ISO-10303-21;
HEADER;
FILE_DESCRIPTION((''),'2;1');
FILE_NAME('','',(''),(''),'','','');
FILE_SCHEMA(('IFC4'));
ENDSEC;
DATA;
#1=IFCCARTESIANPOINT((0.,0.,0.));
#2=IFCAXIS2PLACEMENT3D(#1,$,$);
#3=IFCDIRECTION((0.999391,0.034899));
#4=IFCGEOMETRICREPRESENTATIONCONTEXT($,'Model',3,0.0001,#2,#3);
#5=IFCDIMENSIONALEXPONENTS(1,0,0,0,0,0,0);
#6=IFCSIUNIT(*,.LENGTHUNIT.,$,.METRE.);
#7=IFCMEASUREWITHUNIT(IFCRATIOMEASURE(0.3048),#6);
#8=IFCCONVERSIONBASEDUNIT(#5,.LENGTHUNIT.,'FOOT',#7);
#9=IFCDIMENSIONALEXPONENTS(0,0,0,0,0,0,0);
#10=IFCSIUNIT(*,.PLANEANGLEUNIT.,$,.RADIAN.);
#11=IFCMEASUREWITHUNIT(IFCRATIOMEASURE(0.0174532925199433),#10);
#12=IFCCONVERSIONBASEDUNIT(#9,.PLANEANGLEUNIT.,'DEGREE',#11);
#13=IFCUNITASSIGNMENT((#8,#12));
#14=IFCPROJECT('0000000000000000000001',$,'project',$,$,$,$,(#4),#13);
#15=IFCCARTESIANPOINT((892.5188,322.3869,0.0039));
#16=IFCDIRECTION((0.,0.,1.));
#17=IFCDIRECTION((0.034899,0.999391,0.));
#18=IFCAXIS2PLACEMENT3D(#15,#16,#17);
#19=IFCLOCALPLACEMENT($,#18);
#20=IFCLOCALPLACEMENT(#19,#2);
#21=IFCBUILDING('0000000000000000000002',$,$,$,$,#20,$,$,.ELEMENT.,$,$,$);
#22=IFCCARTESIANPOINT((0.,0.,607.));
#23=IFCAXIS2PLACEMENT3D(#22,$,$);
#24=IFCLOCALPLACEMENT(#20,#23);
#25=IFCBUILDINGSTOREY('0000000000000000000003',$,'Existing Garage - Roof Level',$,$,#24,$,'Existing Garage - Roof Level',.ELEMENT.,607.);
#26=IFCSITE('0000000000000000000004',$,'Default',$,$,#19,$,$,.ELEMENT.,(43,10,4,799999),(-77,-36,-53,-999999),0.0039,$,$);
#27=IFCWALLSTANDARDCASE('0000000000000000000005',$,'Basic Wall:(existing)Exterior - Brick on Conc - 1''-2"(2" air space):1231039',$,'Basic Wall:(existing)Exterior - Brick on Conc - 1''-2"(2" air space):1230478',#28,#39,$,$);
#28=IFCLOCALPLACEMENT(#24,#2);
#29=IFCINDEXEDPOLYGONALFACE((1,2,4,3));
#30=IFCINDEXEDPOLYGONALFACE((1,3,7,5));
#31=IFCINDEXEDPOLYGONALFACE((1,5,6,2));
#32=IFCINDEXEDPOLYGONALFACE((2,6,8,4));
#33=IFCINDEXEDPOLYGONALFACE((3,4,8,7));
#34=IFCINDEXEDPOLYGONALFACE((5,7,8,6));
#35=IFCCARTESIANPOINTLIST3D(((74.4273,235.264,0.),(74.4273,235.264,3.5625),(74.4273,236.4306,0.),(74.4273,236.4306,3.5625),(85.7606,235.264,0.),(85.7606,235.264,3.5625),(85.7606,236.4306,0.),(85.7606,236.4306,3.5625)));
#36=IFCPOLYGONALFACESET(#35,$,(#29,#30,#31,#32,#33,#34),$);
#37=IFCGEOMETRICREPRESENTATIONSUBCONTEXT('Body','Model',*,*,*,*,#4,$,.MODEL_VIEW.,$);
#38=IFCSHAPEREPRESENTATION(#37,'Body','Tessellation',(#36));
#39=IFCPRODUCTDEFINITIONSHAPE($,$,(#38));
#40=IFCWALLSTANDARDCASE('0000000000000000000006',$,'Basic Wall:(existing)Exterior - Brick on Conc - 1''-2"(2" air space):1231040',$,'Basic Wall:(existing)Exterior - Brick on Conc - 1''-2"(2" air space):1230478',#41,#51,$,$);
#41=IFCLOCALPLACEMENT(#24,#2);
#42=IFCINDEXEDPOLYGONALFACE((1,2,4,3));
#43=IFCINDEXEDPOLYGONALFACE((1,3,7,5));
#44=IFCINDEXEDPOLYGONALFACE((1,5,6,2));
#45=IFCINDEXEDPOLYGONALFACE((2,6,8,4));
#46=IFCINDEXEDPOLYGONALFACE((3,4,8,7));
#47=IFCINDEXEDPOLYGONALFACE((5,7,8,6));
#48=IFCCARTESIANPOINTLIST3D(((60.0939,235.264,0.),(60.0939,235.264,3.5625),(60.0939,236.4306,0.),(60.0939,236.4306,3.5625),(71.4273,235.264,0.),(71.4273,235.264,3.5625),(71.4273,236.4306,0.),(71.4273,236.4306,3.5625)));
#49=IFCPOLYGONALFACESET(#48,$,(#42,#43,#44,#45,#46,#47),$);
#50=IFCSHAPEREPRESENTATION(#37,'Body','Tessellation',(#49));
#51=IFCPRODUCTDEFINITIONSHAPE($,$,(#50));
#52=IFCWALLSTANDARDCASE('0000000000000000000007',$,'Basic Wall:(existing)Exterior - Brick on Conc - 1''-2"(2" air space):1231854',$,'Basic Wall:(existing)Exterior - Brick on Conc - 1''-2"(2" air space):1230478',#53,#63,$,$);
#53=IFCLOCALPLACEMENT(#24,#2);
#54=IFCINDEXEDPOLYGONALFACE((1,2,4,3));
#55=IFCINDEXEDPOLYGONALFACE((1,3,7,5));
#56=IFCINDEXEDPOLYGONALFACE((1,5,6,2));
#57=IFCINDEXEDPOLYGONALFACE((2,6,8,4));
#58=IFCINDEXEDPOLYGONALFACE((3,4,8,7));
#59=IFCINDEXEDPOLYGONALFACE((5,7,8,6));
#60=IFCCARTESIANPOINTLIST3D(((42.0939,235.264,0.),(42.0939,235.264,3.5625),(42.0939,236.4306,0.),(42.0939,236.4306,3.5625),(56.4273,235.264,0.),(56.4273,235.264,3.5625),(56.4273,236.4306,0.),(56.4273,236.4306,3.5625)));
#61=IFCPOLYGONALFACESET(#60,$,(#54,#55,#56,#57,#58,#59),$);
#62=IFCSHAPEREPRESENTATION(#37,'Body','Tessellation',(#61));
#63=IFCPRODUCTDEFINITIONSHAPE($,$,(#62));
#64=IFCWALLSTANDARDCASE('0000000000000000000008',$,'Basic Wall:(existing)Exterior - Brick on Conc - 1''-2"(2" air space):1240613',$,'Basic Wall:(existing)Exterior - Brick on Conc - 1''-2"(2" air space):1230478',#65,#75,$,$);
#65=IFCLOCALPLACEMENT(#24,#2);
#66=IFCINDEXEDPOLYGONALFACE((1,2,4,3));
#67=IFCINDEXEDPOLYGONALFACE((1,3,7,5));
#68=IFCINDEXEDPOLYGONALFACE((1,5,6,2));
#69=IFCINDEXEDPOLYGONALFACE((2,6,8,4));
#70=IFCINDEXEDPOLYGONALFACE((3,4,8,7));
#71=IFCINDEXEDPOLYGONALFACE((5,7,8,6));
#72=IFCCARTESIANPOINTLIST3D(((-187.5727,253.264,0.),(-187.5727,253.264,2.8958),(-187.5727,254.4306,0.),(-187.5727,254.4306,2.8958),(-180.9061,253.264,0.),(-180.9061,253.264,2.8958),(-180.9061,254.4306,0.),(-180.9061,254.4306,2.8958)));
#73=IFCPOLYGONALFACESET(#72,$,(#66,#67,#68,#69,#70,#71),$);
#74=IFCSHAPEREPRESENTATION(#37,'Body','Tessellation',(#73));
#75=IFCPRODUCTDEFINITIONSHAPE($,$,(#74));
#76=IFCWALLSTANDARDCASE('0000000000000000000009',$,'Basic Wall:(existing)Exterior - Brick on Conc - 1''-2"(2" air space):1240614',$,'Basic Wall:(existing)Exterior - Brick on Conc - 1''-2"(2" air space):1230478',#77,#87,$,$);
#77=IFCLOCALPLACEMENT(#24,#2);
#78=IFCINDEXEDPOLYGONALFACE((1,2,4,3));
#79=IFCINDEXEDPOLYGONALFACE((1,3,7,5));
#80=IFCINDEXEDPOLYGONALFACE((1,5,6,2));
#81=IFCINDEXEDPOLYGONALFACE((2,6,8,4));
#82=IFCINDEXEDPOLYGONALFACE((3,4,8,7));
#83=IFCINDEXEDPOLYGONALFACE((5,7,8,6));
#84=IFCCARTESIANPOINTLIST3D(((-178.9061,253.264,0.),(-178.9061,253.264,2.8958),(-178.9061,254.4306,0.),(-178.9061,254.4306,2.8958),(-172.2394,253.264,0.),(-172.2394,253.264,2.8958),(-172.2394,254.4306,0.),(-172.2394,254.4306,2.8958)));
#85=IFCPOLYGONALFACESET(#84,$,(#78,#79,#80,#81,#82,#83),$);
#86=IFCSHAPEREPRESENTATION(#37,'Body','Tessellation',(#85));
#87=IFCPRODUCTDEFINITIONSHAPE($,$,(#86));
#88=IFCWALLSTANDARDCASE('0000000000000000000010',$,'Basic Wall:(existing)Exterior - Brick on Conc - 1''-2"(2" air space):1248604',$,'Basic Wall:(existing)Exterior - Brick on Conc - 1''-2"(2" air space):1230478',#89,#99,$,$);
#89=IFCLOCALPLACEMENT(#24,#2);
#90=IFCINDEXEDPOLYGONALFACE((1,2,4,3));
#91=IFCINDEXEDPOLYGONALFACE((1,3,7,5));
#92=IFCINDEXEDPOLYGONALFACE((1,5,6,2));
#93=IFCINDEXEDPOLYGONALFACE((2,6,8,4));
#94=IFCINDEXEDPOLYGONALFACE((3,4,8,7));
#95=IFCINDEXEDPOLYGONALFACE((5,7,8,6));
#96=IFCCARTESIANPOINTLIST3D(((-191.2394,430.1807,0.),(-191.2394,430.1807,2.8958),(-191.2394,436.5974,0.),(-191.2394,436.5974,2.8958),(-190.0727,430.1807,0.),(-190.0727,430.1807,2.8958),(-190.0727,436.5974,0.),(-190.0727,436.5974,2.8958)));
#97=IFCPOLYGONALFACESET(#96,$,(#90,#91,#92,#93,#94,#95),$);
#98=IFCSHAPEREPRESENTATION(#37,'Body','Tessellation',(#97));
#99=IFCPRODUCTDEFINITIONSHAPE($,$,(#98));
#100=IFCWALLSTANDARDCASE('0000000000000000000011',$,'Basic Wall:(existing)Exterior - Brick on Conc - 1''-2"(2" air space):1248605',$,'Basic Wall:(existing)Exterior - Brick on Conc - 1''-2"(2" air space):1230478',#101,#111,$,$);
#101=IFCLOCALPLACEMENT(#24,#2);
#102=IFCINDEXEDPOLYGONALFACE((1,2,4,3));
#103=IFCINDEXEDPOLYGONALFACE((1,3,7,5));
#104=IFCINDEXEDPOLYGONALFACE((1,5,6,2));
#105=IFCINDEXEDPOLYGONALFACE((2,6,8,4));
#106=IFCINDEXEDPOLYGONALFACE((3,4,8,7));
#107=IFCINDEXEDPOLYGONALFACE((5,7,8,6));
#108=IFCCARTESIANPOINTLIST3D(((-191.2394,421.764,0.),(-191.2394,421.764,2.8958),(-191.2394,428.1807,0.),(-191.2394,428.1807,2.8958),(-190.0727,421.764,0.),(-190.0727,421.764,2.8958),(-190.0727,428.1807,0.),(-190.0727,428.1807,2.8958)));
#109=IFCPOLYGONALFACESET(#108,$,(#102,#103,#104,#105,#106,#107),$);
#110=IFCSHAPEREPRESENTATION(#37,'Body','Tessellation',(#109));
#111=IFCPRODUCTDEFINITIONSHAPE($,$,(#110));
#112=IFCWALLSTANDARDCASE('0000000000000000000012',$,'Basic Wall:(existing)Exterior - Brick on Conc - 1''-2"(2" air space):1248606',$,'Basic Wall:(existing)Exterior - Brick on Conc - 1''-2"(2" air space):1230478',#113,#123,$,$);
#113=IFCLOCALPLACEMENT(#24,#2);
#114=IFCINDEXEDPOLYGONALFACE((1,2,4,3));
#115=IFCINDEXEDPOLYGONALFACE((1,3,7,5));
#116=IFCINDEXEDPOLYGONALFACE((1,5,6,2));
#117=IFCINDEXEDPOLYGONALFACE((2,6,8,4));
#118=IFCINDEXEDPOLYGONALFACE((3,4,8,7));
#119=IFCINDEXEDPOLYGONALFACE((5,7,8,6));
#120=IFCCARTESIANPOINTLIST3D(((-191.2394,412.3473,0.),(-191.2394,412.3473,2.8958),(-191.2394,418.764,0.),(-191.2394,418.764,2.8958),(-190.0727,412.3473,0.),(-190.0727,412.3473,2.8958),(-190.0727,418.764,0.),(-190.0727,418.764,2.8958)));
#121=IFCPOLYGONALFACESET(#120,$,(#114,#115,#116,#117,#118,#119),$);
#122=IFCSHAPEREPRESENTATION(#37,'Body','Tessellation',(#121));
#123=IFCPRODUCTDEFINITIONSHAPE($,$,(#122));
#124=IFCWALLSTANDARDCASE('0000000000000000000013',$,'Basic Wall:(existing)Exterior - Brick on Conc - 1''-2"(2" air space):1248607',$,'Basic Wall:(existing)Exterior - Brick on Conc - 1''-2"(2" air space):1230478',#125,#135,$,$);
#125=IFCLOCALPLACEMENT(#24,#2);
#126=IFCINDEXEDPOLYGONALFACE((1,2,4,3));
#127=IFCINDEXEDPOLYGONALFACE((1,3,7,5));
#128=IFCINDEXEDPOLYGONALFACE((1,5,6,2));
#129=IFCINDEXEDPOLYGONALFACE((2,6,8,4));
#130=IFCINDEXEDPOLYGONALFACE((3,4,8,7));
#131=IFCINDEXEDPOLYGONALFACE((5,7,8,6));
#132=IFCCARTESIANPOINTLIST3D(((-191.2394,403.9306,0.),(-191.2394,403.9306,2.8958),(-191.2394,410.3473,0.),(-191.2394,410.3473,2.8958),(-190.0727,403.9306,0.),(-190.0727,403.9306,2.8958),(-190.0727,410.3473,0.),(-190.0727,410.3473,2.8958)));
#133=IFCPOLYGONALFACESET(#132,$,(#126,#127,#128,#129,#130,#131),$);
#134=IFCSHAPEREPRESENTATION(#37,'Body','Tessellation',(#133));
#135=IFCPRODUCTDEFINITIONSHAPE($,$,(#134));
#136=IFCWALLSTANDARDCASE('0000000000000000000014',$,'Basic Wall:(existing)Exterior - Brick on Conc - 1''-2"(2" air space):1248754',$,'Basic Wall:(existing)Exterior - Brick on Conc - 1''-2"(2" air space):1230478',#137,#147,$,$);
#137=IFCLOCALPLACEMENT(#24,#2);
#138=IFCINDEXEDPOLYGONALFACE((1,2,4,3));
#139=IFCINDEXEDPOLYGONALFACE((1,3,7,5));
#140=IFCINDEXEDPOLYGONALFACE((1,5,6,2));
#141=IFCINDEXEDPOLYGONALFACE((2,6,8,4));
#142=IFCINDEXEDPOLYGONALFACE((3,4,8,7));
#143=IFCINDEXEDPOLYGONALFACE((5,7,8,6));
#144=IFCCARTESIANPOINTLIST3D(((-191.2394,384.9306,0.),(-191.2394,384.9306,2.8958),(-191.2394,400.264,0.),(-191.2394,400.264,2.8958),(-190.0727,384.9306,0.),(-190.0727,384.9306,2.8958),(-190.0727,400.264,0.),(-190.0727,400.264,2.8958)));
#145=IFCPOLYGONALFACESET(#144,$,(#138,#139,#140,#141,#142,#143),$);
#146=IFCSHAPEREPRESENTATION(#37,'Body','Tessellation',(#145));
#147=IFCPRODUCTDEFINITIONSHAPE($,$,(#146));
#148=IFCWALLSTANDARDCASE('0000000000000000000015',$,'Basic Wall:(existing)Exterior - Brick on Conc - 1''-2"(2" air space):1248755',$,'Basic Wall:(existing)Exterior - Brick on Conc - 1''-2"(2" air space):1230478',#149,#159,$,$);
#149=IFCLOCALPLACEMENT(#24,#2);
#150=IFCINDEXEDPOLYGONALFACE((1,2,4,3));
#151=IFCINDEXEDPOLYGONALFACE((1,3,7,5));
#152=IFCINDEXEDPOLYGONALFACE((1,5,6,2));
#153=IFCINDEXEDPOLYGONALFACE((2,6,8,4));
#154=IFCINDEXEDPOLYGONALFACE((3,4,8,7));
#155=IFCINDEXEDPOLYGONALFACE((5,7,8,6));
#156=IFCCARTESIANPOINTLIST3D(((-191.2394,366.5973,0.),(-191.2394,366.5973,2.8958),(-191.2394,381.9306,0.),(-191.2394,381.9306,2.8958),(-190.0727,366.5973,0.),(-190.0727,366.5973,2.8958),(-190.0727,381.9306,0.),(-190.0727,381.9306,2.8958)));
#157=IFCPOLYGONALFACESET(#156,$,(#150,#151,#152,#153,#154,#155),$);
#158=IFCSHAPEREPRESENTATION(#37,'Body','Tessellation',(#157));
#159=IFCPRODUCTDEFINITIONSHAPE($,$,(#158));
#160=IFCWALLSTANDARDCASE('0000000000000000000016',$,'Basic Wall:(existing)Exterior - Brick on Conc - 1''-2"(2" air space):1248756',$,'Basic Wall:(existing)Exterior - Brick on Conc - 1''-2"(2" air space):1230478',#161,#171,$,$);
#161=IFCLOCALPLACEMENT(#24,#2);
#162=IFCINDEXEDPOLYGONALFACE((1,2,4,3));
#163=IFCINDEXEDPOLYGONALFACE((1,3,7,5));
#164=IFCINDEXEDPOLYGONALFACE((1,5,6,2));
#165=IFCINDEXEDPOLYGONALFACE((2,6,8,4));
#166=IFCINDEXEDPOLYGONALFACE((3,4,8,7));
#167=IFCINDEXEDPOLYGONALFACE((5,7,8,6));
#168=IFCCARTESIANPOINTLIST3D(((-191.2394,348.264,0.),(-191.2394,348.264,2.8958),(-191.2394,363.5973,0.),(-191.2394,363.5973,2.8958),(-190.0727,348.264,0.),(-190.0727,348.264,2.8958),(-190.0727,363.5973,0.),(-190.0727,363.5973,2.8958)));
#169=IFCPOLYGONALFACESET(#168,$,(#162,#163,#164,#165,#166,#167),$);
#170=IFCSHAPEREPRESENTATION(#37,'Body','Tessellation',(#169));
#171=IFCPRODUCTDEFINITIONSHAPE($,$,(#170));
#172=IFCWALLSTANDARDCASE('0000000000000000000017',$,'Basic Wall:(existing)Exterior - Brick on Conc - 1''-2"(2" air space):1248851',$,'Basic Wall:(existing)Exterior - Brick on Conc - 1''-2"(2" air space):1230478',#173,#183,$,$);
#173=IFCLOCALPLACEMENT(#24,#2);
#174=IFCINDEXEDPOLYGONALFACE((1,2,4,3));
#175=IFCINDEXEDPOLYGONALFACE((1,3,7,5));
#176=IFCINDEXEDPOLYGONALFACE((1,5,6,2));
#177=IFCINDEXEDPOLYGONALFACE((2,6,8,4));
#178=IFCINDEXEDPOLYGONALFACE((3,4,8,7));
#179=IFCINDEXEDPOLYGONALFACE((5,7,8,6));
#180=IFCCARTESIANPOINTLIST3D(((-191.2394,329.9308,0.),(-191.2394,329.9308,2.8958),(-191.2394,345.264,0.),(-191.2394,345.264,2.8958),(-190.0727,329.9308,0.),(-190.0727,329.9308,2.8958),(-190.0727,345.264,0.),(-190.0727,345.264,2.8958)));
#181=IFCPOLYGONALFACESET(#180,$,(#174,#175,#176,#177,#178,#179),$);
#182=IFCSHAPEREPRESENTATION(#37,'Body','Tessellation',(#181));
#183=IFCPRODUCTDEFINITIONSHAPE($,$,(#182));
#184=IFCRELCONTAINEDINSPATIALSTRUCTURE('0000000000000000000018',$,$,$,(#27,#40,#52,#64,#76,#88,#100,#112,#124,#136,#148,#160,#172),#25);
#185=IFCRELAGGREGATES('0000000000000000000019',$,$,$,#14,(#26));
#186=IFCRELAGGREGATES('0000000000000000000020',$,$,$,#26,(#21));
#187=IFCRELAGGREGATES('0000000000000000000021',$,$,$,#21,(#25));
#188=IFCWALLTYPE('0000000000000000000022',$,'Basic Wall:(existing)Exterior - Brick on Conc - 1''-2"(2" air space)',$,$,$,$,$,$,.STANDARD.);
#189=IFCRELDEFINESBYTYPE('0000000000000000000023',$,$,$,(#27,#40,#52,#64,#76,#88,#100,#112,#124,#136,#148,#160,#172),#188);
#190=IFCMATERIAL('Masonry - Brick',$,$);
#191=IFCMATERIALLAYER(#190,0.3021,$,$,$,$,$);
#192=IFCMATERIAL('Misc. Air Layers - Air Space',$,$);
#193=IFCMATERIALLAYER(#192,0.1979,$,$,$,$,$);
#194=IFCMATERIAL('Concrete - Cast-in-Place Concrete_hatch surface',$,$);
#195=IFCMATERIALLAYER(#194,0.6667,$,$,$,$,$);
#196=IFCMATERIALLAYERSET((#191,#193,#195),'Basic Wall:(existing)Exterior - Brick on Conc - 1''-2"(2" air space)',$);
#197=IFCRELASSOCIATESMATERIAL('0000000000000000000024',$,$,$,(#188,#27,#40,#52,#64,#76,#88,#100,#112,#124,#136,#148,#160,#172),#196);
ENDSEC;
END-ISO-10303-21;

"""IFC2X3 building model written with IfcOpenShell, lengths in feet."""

from ifc_helpers import new_model, entity, si_unit, converted_unit, direction, frame, frame_2d, origin, place, context, subcontext, project, spatial, rectangle, extrude, material, layer, layer_set, layer_usage, type_object, element, save


model = new_model("IFC2X3")

# Units and contexts
model_context = context("Model", 3, precision=0.0001, world=origin(), true_north=direction((0.999391, 0.034899)))
body_context = subcontext(model_context, "Body", "Model", "MODEL_VIEW")
ifc_project = project(units=[converted_unit("LENGTHUNIT", "FOOT", entity("IfcRatioMeasure", 0.3048), si_unit("LENGTHUNIT", "METRE"), dimensions=[1, 0, 0, 0, 0, 0, 0]), converted_unit("PLANEANGLEUNIT", "DEGREE", entity("IfcRatioMeasure", 0.0174532925199433), si_unit("PLANEANGLEUNIT", "RADIAN"), dimensions=[0, 0, 0, 0, 0, 0, 0])], contexts=[model_context])

# Site, building, storey
site_placement = place(None, frame((892.5188, 322.3869, 0.0039), z_axis=(0.0, 0.0, 1.0), x_axis=(0.034899, 0.999391, 0.0)))
site = spatial("IfcSite", under=ifc_project, at=site_placement, Name="Default", CompositionType="ELEMENT", RefLatitude=(43, 10, 4, 799999), RefLongitude=(-77, -36, -53, -999999), RefElevation=0.0039)
building_placement = place(site_placement, origin())
building = spatial("IfcBuilding", under=site, at=building_placement, CompositionType="ELEMENT")
storey_placement = place(building_placement, frame((0.0, 0.0, 607.0)))
storey = spatial("IfcBuildingStorey", under=building, at=storey_placement, Name="Existing Garage - Roof Level", LongName="Existing Garage - Roof Level", CompositionType="ELEMENT", Elevation=607.0)

# Walls
ifc_material_1 = material(Name="Masonry - Brick")
ifc_layer_1 = layer(ifc_material_1, 0.3021)
ifc_material_2 = material(Name="Misc. Air Layers - Air Space")
ifc_layer_2 = layer(ifc_material_2, 0.1979)
ifc_material_3 = material(Name="Concrete - Cast-in-Place Concrete_hatch surface")
ifc_layer_3 = layer(ifc_material_3, 0.6667)
ifc_layer_set_1 = layer_set([ifc_layer_1, ifc_layer_2, ifc_layer_3], Name="Basic Wall:(existing)Exterior - Brick on Conc - 1'-2\"(2\" air space)")
ifc_layer_usage_1 = layer_usage(ifc_layer_set_1, "AXIS2", "POSITIVE", -0.5833)
wall_type_1 = type_object("IfcWallType", Name="Basic Wall:(existing)Exterior - Brick on Conc - 1'-2\"(2\" air space)", PredefinedType="STANDARD", material=ifc_layer_set_1)
wall_1_placement = place(storey_placement, frame((74.4273, 235.8473, 0.0)))
element("IfcWallStandardCase", 1, at=wall_1_placement, inside=storey, type_object=wall_type_1, material=ifc_layer_usage_1, Name="Basic Wall:(existing)Exterior - Brick on Conc - 1'-2\"(2\" air space):1231039", ObjectType="Basic Wall:(existing)Exterior - Brick on Conc - 1'-2\"(2\" air space):1230478", context=body_context, shape_type="SweptSolid", body=[
    extrude(rectangle(XDim=11.3333, YDim=1.1667, at=frame_2d((5.6667, 0.0), x_axis=(-1.0, 0.0))), origin(), (0.0, 0.0, 1.0), 3.5625),
])
ifc_layer_usage_2 = layer_usage(ifc_layer_set_1, "AXIS2", "POSITIVE", -0.5833)
wall_2_placement = place(storey_placement, frame((60.0939, 235.8473, 0.0)))
element("IfcWallStandardCase", 2, at=wall_2_placement, inside=storey, type_object=wall_type_1, material=ifc_layer_usage_2, Name="Basic Wall:(existing)Exterior - Brick on Conc - 1'-2\"(2\" air space):1231040", ObjectType="Basic Wall:(existing)Exterior - Brick on Conc - 1'-2\"(2\" air space):1230478", context=body_context, shape_type="SweptSolid", body=[
    extrude(rectangle(XDim=11.3334, YDim=1.1667, at=frame_2d((5.6667, 0.0), x_axis=(-1.0, 0.0))), origin(), (0.0, 0.0, 1.0), 3.5625),
])
ifc_layer_usage_3 = layer_usage(ifc_layer_set_1, "AXIS2", "POSITIVE", -0.5833)
wall_3_placement = place(storey_placement, frame((42.0939, 235.8473, 0.0)))
element("IfcWallStandardCase", 3, at=wall_3_placement, inside=storey, type_object=wall_type_1, material=ifc_layer_usage_3, Name="Basic Wall:(existing)Exterior - Brick on Conc - 1'-2\"(2\" air space):1231854", ObjectType="Basic Wall:(existing)Exterior - Brick on Conc - 1'-2\"(2\" air space):1230478", context=body_context, shape_type="SweptSolid", body=[
    extrude(rectangle(XDim=14.3333, YDim=1.1667, at=frame_2d((7.1667, 0.0), x_axis=(-1.0, 0.0))), origin(), (0.0, 0.0, 1.0), 3.5625),
])
ifc_layer_usage_4 = layer_usage(ifc_layer_set_1, "AXIS2", "POSITIVE", -0.5833)
wall_4_placement = place(storey_placement, frame((-187.5727, 253.8473, 0.0)))
element("IfcWallStandardCase", 4, at=wall_4_placement, inside=storey, type_object=wall_type_1, material=ifc_layer_usage_4, Name="Basic Wall:(existing)Exterior - Brick on Conc - 1'-2\"(2\" air space):1240613", ObjectType="Basic Wall:(existing)Exterior - Brick on Conc - 1'-2\"(2\" air space):1230478", context=body_context, shape_type="SweptSolid", body=[
    extrude(rectangle(XDim=6.6667, YDim=1.1667, at=frame_2d((3.3333, 0.0), x_axis=(-1.0, 0.0))), origin(), (0.0, 0.0, 1.0), 2.8958),
])
ifc_layer_usage_5 = layer_usage(ifc_layer_set_1, "AXIS2", "POSITIVE", -0.5833)
wall_5_placement = place(storey_placement, frame((-178.9061, 253.8473, 0.0)))
element("IfcWallStandardCase", 5, at=wall_5_placement, inside=storey, type_object=wall_type_1, material=ifc_layer_usage_5, Name="Basic Wall:(existing)Exterior - Brick on Conc - 1'-2\"(2\" air space):1240614", ObjectType="Basic Wall:(existing)Exterior - Brick on Conc - 1'-2\"(2\" air space):1230478", context=body_context, shape_type="SweptSolid", body=[
    extrude(rectangle(XDim=6.6667, YDim=1.1667, at=frame_2d((3.3333, 0.0), x_axis=(-1.0, 0.0))), origin(), (0.0, 0.0, 1.0), 2.8958),
])
ifc_layer_usage_6 = layer_usage(ifc_layer_set_1, "AXIS2", "POSITIVE", -0.5833)
wall_6_placement = place(storey_placement, frame((-190.6561, 436.5974, 0.0), z_axis=(0.0, 0.0, 1.0), x_axis=(0.0, -1.0, 0.0)))
element("IfcWallStandardCase", 6, at=wall_6_placement, inside=storey, type_object=wall_type_1, material=ifc_layer_usage_6, Name="Basic Wall:(existing)Exterior - Brick on Conc - 1'-2\"(2\" air space):1248604", ObjectType="Basic Wall:(existing)Exterior - Brick on Conc - 1'-2\"(2\" air space):1230478", context=body_context, shape_type="SweptSolid", body=[
    extrude(rectangle(XDim=6.4167, YDim=1.1667, at=frame_2d((3.2084, 0.0), x_axis=(-1.0, 0.0))), origin(), (0.0, 0.0, 1.0), 2.8958),
])
ifc_layer_usage_7 = layer_usage(ifc_layer_set_1, "AXIS2", "POSITIVE", -0.5833)
wall_7_placement = place(storey_placement, frame((-190.6561, 428.1807, 0.0), z_axis=(0.0, 0.0, 1.0), x_axis=(0.0, -1.0, 0.0)))
element("IfcWallStandardCase", 7, at=wall_7_placement, inside=storey, type_object=wall_type_1, material=ifc_layer_usage_7, Name="Basic Wall:(existing)Exterior - Brick on Conc - 1'-2\"(2\" air space):1248605", ObjectType="Basic Wall:(existing)Exterior - Brick on Conc - 1'-2\"(2\" air space):1230478", context=body_context, shape_type="SweptSolid", body=[
    extrude(rectangle(XDim=6.4167, YDim=1.1667, at=frame_2d((3.2084, 0.0), x_axis=(-1.0, 0.0))), origin(), (0.0, 0.0, 1.0), 2.8958),
])
ifc_layer_usage_8 = layer_usage(ifc_layer_set_1, "AXIS2", "POSITIVE", -0.5833)
wall_8_placement = place(storey_placement, frame((-190.6561, 418.764, 0.0), z_axis=(0.0, 0.0, 1.0), x_axis=(0.0, -1.0, 0.0)))
element("IfcWallStandardCase", 8, at=wall_8_placement, inside=storey, type_object=wall_type_1, material=ifc_layer_usage_8, Name="Basic Wall:(existing)Exterior - Brick on Conc - 1'-2\"(2\" air space):1248606", ObjectType="Basic Wall:(existing)Exterior - Brick on Conc - 1'-2\"(2\" air space):1230478", context=body_context, shape_type="SweptSolid", body=[
    extrude(rectangle(XDim=6.4167, YDim=1.1667, at=frame_2d((3.2084, 0.0), x_axis=(-1.0, 0.0))), origin(), (0.0, 0.0, 1.0), 2.8958),
])
ifc_layer_usage_9 = layer_usage(ifc_layer_set_1, "AXIS2", "POSITIVE", -0.5833)
wall_9_placement = place(storey_placement, frame((-190.6561, 410.3473, 0.0), z_axis=(0.0, 0.0, 1.0), x_axis=(0.0, -1.0, 0.0)))
element("IfcWallStandardCase", 9, at=wall_9_placement, inside=storey, type_object=wall_type_1, material=ifc_layer_usage_9, Name="Basic Wall:(existing)Exterior - Brick on Conc - 1'-2\"(2\" air space):1248607", ObjectType="Basic Wall:(existing)Exterior - Brick on Conc - 1'-2\"(2\" air space):1230478", context=body_context, shape_type="SweptSolid", body=[
    extrude(rectangle(XDim=6.4167, YDim=1.1667, at=frame_2d((3.2084, 0.0), x_axis=(-1.0, 0.0))), origin(), (0.0, 0.0, 1.0), 2.8958),
])
ifc_layer_usage_10 = layer_usage(ifc_layer_set_1, "AXIS2", "POSITIVE", -0.5833)
wall_10_placement = place(storey_placement, frame((-190.6561, 400.264, 0.0), z_axis=(0.0, 0.0, 1.0), x_axis=(0.0, -1.0, 0.0)))
element("IfcWallStandardCase", 10, at=wall_10_placement, inside=storey, type_object=wall_type_1, material=ifc_layer_usage_10, Name="Basic Wall:(existing)Exterior - Brick on Conc - 1'-2\"(2\" air space):1248754", ObjectType="Basic Wall:(existing)Exterior - Brick on Conc - 1'-2\"(2\" air space):1230478", context=body_context, shape_type="SweptSolid", body=[
    extrude(rectangle(XDim=15.3333, YDim=1.1667, at=frame_2d((7.6667, 0.0), x_axis=(-1.0, 0.0))), origin(), (0.0, 0.0, 1.0), 2.8958),
])
ifc_layer_usage_11 = layer_usage(ifc_layer_set_1, "AXIS2", "POSITIVE", -0.5833)
wall_11_placement = place(storey_placement, frame((-190.6561, 381.9306, 0.0), z_axis=(0.0, 0.0, 1.0), x_axis=(0.0, -1.0, 0.0)))
element("IfcWallStandardCase", 11, at=wall_11_placement, inside=storey, type_object=wall_type_1, material=ifc_layer_usage_11, Name="Basic Wall:(existing)Exterior - Brick on Conc - 1'-2\"(2\" air space):1248755", ObjectType="Basic Wall:(existing)Exterior - Brick on Conc - 1'-2\"(2\" air space):1230478", context=body_context, shape_type="SweptSolid", body=[
    extrude(rectangle(XDim=15.3333, YDim=1.1667, at=frame_2d((7.6667, 0.0), x_axis=(-1.0, 0.0))), origin(), (0.0, 0.0, 1.0), 2.8958),
])
ifc_layer_usage_12 = layer_usage(ifc_layer_set_1, "AXIS2", "POSITIVE", -0.5833)
wall_12_placement = place(storey_placement, frame((-190.6561, 363.5973, 0.0), z_axis=(0.0, 0.0, 1.0), x_axis=(0.0, -1.0, 0.0)))
element("IfcWallStandardCase", 12, at=wall_12_placement, inside=storey, type_object=wall_type_1, material=ifc_layer_usage_12, Name="Basic Wall:(existing)Exterior - Brick on Conc - 1'-2\"(2\" air space):1248756", ObjectType="Basic Wall:(existing)Exterior - Brick on Conc - 1'-2\"(2\" air space):1230478", context=body_context, shape_type="SweptSolid", body=[
    extrude(rectangle(XDim=15.3333, YDim=1.1667, at=frame_2d((7.6667, 0.0), x_axis=(-1.0, 0.0))), origin(), (0.0, 0.0, 1.0), 2.8958),
])
ifc_layer_usage_13 = layer_usage(ifc_layer_set_1, "AXIS2", "POSITIVE", -0.5833)
wall_13_placement = place(storey_placement, frame((-190.6561, 345.264, 0.0), z_axis=(0.0, 0.0, 1.0), x_axis=(0.0, -1.0, 0.0)))
element("IfcWallStandardCase", 13, at=wall_13_placement, inside=storey, type_object=wall_type_1, material=ifc_layer_usage_13, Name="Basic Wall:(existing)Exterior - Brick on Conc - 1'-2\"(2\" air space):1248851", ObjectType="Basic Wall:(existing)Exterior - Brick on Conc - 1'-2\"(2\" air space):1230478", context=body_context, shape_type="SweptSolid", body=[
    extrude(rectangle(XDim=15.3331, YDim=1.1667, at=frame_2d((7.6666, 0.0), x_axis=(-1.0, 0.0))), origin(), (0.0, 0.0, 1.0), 2.8958),
])

save(model, "model.ifc")
